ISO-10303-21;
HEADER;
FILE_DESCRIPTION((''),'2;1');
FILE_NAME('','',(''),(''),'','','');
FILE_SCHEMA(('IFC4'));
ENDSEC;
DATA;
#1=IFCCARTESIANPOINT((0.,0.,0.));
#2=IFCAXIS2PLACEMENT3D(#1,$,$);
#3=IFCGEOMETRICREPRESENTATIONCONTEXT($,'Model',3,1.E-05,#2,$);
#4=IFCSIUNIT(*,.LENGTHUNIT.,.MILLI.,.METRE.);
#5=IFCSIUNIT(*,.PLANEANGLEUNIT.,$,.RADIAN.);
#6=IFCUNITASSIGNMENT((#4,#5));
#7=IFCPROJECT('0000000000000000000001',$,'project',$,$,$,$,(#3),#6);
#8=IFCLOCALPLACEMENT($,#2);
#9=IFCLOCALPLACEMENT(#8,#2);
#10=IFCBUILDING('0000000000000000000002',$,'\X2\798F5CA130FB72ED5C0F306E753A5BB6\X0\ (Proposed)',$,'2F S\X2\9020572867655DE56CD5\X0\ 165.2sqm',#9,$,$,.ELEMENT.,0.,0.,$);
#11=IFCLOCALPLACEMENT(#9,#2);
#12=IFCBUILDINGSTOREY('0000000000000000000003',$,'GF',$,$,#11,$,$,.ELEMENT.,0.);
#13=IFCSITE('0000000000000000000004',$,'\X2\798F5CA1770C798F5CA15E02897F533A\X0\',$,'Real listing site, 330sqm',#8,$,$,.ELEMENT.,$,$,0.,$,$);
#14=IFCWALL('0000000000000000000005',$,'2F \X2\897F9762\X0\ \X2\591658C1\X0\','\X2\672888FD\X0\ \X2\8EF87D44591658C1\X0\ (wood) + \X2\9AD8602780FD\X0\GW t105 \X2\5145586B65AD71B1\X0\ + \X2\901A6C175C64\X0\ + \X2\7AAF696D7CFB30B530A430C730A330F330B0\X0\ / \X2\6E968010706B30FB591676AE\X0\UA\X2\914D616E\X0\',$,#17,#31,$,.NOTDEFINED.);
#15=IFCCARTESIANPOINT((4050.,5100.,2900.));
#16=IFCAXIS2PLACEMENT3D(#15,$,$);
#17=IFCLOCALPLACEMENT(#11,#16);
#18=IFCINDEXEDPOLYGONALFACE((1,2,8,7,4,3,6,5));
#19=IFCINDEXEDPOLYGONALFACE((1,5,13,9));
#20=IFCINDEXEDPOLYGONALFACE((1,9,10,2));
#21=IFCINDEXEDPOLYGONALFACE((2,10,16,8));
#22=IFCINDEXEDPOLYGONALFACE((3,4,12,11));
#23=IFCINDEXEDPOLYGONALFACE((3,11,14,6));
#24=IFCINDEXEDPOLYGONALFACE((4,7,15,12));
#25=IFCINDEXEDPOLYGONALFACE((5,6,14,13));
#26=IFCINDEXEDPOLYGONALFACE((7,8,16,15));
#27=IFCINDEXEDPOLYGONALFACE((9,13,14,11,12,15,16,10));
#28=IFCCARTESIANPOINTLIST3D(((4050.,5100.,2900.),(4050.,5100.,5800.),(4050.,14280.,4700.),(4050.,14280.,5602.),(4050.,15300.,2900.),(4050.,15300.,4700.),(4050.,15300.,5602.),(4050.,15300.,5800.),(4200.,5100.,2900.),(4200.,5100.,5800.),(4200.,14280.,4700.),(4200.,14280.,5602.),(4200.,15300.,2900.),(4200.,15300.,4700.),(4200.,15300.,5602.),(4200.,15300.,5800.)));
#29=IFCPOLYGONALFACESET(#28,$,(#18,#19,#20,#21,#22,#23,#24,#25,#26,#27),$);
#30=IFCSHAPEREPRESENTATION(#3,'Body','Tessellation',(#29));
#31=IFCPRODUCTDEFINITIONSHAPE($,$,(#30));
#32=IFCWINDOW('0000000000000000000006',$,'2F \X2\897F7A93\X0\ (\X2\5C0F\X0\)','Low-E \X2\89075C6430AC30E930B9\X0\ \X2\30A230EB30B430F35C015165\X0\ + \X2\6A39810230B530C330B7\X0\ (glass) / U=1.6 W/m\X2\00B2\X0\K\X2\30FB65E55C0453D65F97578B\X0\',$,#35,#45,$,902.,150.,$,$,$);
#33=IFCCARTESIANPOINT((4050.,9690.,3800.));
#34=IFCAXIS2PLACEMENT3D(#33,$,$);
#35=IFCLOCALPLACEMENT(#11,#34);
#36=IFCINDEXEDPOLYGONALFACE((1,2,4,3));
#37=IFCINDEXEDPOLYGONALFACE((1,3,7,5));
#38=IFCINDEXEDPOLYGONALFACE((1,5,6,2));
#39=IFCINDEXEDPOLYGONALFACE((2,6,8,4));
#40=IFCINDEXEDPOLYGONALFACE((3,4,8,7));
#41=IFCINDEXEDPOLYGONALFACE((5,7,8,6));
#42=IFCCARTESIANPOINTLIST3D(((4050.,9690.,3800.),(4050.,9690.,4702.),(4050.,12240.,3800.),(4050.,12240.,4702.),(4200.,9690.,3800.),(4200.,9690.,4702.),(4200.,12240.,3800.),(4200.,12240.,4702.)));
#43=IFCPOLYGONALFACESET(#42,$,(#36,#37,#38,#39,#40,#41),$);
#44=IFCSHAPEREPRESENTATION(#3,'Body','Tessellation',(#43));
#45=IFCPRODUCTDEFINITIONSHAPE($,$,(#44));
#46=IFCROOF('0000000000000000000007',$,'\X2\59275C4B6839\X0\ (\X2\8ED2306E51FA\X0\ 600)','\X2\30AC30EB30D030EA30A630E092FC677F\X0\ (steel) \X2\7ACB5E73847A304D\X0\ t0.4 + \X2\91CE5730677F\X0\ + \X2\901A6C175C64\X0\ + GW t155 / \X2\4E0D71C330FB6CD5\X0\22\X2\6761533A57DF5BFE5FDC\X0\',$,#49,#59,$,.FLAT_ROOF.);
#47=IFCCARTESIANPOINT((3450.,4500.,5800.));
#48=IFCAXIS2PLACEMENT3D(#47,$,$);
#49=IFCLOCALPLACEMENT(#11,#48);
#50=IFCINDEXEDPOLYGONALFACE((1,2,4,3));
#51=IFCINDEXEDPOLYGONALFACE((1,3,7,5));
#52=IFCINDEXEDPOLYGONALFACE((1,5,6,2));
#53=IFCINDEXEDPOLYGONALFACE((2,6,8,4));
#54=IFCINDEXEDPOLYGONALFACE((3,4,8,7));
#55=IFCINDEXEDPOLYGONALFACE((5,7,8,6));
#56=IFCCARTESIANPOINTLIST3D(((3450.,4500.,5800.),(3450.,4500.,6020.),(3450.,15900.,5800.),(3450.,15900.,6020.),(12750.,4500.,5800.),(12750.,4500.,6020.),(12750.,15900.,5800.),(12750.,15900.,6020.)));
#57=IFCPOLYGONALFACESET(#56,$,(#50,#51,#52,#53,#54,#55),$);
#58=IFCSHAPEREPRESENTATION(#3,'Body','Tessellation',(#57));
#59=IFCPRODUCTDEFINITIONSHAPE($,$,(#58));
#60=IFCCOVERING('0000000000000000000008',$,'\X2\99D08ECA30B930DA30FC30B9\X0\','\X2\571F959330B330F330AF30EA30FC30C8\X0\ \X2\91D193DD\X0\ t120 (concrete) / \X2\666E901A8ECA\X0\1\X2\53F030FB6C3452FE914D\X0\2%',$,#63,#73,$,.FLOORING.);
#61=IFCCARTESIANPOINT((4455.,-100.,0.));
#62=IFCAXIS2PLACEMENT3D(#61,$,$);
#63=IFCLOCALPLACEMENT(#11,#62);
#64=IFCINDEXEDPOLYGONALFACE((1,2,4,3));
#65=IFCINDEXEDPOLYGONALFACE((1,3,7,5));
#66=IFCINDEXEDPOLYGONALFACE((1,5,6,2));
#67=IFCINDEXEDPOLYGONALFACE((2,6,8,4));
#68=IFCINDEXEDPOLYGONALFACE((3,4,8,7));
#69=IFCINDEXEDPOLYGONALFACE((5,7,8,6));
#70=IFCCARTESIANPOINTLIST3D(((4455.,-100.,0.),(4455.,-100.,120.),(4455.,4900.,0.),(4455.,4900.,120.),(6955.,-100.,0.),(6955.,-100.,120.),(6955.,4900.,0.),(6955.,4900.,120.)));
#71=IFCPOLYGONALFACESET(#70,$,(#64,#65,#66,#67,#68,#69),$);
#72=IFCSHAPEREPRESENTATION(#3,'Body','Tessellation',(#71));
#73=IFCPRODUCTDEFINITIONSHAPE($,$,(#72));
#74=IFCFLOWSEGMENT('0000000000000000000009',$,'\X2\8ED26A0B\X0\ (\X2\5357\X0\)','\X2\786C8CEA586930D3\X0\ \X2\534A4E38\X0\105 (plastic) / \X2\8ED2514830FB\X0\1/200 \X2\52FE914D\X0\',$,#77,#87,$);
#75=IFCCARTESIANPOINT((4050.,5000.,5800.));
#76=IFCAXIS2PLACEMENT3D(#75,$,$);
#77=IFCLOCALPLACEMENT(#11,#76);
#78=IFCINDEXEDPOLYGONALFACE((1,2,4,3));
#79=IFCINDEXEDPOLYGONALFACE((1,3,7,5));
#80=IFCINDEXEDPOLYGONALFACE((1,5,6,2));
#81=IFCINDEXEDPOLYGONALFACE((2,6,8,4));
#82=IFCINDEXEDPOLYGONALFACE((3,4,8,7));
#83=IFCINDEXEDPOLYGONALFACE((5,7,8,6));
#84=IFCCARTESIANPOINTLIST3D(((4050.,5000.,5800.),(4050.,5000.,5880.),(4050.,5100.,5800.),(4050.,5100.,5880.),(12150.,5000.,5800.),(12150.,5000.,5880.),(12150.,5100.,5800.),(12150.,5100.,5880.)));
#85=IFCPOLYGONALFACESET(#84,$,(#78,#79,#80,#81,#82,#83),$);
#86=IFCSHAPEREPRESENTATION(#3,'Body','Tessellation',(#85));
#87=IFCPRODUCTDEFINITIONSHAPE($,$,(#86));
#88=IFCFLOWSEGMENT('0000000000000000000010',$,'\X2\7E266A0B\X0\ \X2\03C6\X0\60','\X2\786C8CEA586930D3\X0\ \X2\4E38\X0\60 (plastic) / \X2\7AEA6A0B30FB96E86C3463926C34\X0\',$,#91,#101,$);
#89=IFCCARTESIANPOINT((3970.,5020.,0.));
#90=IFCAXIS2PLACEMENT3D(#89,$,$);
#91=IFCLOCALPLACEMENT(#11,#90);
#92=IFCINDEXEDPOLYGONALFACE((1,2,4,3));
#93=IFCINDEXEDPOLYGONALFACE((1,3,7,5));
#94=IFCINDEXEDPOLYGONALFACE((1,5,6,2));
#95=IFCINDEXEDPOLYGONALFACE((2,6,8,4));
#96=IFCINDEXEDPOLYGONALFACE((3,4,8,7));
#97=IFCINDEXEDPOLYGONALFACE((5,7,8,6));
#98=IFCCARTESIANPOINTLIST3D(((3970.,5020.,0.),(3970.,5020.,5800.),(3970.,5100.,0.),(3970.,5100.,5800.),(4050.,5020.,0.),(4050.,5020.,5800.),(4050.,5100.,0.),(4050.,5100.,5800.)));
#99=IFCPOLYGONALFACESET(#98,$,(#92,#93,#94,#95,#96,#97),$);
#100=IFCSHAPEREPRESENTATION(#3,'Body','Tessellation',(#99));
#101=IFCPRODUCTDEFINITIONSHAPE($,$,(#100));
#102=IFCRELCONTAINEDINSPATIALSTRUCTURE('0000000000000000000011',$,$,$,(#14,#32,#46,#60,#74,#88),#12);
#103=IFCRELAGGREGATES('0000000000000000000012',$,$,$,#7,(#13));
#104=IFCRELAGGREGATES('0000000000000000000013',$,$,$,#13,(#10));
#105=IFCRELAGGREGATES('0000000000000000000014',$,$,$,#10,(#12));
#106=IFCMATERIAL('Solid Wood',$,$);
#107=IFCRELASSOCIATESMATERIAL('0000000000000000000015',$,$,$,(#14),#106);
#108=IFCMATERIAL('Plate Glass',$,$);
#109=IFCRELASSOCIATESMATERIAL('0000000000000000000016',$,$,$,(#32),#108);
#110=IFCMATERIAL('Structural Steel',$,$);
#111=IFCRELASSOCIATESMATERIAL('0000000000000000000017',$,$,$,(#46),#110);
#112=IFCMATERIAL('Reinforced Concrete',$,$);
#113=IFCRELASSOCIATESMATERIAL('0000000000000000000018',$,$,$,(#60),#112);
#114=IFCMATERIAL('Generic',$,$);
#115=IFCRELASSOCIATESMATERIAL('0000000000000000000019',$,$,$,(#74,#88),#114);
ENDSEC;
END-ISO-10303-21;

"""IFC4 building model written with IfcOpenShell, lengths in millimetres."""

from ifc_helpers import new_model, si_unit, frame, frame_2d, origin, place, context, project, spatial, rectangle, extrude, material, element, fill, save


model = new_model("IFC4")

# Units and contexts
model_context = context("Model", 3, precision=1e-05, world=origin())
ifc_project = project(units=[si_unit("LENGTHUNIT", "METRE", prefix="MILLI"), si_unit("PLANEANGLEUNIT", "RADIAN")], contexts=[model_context])

# Site, building, storey
site_placement = place(None, origin())
site = spatial("IfcSite", under=ifc_project, at=site_placement, Name="福岡県福岡市西区", ObjectType="Real listing site, 330sqm", CompositionType="ELEMENT", RefElevation=0.0)
building_placement = place(site_placement, origin())
building = spatial("IfcBuilding", under=site, at=building_placement, Name="福岡・狭小の町家 (Proposed)", ObjectType="2F S造在来工法 165.2sqm", CompositionType="ELEMENT", ElevationOfRefHeight=0.0, ElevationOfTerrain=0.0)
storey_placement = place(building_placement, origin())
storey = spatial("IfcBuildingStorey", under=building, at=storey_placement, Name="GF", CompositionType="ELEMENT", Elevation=0.0)

# Shared definitions
ifc_material_1 = material(Name="Solid Wood")

# Shared definitions
ifc_material_2 = material(Name="Reinforced Concrete")

# Shared definitions
ifc_material_3 = material(Name="Plate Glass")

# Wall, opening, window
wall_1_placement = place(storey_placement, frame((4050.0, 5100.0, 2900.0)))
wall_1 = element("IfcWall", 1, at=wall_1_placement, inside=storey, material=ifc_material_1, Name="2F 西面 外壁", Description="木製 軸組外壁 (wood) + 高性能GW t105 充填断熱 + 通気層 + 窯業系サイディング / 準耐火・外皮UA配慮", PredefinedType="NOTDEFINED", context=model_context, shape_type="SweptSolid", body=[
    extrude(rectangle(XDim=150.0, YDim=10200.0, at=frame_2d((75.0, 5100.0))), frame((4050.0, 5100.0, 2900.0)), (0.0, 0.0, 1.0), 2900.0),
])
opening_1_placement = place(storey_placement, frame((4050.0, 9690.0, 3800.0)))
opening_1 = element("IfcOpeningElement", 2, at=opening_1_placement, cuts=wall_1, PredefinedType="NOTDEFINED", context=model_context, shape_type="SweptSolid", body=[
    extrude(rectangle(XDim=150.0, YDim=2550.0, at=frame_2d((75.0, 1275.0))), frame((4050.0, 9690.0, 3800.0)), (0.0, 0.0, 1.0), 902.0),
])
window_1_placement = place(storey_placement, frame((4050.0, 9690.0, 3800.0)))
window_1 = element("IfcWindow", 3, at=window_1_placement, inside=storey, material=ifc_material_3, Name="2F 西窓 (小)", Description="Low-E 複層ガラス アルゴン封入 + 樹脂サッシ (glass) / U=1.6 W/m²K・日射取得型", OverallHeight=902.0, OverallWidth=150.0, context=model_context, shape_type="SweptSolid", body=[
    extrude(rectangle(XDim=150.0, YDim=2550.0, at=frame_2d((75.0, 1275.0))), frame((4050.0, 9690.0, 3800.0)), (0.0, 0.0, 1.0), 902.0),
])
fill(opening_1, window_1)

# Roof
ifc_material_4 = material(Name="Structural Steel")
roof_placement = place(storey_placement, frame((3450.0, 4500.0, 5800.0)))
element("IfcRoof", 4, at=roof_placement, inside=storey, material=ifc_material_4, Name="大屋根 (軒の出 600)", Description="ガルバリウム鋼板 (steel) 立平葺き t0.4 + 野地板 + 通気層 + GW t155 / 不燃・法22条区域対応", PredefinedType="FLAT_ROOF", context=model_context, shape_type="SweptSolid", body=[
    extrude(rectangle(XDim=9300.0, YDim=11400.0, at=frame_2d((4650.0, 5700.0))), frame((3450.0, 4500.0, 5800.0)), (0.0, 0.0, 1.0), 220.0),
])

# Covering
covering_placement = place(storey_placement, frame((4455.0, -100.0, 0.0)))
element("IfcCovering", 5, at=covering_placement, inside=storey, material=ifc_material_2, Name="駐車スペース", Description="土間コンクリート 金鏝 t120 (concrete) / 普通車1台・水勾配2%", PredefinedType="FLOORING", context=model_context, shape_type="SweptSolid", body=[
    extrude(rectangle(XDim=2500.0, YDim=5000.0, at=frame_2d((1250.0, 2500.0))), frame((4455.0, -100.0, 0.0)), (0.0, 0.0, 1.0), 120.0),
])

# Flow segments
ifc_material_5 = material(Name="Generic")
flow_segment_1_placement = place(storey_placement, frame((4050.0, 5000.0, 5800.0)))
element("IfcFlowSegment", 6, at=flow_segment_1_placement, inside=storey, material=ifc_material_5, Name="軒樋 (南)", Description="硬質塩ビ 半丸105 (plastic) / 軒先・1/200 勾配", context=model_context, shape_type="SweptSolid", body=[
    extrude(rectangle(XDim=8100.0, YDim=100.0, at=frame_2d((4050.0, 50.0))), frame((4050.0, 5000.0, 5800.0)), (0.0, 0.0, 1.0), 80.0),
])
flow_segment_2_placement = place(storey_placement, frame((3970.0, 5020.0, 0.0)))
element("IfcFlowSegment", 7, at=flow_segment_2_placement, inside=storey, material=ifc_material_5, Name="縦樋 φ60", Description="硬質塩ビ 丸60 (plastic) / 竪樋・雨水排水", context=model_context, shape_type="SweptSolid", body=[
    extrude(rectangle(XDim=80.0, YDim=80.0, at=frame_2d((40.0, 40.0))), frame((3970.0, 5020.0, 0.0)), (0.0, 0.0, 1.0), 5800.0),
])

save(model, "model.ifc")
